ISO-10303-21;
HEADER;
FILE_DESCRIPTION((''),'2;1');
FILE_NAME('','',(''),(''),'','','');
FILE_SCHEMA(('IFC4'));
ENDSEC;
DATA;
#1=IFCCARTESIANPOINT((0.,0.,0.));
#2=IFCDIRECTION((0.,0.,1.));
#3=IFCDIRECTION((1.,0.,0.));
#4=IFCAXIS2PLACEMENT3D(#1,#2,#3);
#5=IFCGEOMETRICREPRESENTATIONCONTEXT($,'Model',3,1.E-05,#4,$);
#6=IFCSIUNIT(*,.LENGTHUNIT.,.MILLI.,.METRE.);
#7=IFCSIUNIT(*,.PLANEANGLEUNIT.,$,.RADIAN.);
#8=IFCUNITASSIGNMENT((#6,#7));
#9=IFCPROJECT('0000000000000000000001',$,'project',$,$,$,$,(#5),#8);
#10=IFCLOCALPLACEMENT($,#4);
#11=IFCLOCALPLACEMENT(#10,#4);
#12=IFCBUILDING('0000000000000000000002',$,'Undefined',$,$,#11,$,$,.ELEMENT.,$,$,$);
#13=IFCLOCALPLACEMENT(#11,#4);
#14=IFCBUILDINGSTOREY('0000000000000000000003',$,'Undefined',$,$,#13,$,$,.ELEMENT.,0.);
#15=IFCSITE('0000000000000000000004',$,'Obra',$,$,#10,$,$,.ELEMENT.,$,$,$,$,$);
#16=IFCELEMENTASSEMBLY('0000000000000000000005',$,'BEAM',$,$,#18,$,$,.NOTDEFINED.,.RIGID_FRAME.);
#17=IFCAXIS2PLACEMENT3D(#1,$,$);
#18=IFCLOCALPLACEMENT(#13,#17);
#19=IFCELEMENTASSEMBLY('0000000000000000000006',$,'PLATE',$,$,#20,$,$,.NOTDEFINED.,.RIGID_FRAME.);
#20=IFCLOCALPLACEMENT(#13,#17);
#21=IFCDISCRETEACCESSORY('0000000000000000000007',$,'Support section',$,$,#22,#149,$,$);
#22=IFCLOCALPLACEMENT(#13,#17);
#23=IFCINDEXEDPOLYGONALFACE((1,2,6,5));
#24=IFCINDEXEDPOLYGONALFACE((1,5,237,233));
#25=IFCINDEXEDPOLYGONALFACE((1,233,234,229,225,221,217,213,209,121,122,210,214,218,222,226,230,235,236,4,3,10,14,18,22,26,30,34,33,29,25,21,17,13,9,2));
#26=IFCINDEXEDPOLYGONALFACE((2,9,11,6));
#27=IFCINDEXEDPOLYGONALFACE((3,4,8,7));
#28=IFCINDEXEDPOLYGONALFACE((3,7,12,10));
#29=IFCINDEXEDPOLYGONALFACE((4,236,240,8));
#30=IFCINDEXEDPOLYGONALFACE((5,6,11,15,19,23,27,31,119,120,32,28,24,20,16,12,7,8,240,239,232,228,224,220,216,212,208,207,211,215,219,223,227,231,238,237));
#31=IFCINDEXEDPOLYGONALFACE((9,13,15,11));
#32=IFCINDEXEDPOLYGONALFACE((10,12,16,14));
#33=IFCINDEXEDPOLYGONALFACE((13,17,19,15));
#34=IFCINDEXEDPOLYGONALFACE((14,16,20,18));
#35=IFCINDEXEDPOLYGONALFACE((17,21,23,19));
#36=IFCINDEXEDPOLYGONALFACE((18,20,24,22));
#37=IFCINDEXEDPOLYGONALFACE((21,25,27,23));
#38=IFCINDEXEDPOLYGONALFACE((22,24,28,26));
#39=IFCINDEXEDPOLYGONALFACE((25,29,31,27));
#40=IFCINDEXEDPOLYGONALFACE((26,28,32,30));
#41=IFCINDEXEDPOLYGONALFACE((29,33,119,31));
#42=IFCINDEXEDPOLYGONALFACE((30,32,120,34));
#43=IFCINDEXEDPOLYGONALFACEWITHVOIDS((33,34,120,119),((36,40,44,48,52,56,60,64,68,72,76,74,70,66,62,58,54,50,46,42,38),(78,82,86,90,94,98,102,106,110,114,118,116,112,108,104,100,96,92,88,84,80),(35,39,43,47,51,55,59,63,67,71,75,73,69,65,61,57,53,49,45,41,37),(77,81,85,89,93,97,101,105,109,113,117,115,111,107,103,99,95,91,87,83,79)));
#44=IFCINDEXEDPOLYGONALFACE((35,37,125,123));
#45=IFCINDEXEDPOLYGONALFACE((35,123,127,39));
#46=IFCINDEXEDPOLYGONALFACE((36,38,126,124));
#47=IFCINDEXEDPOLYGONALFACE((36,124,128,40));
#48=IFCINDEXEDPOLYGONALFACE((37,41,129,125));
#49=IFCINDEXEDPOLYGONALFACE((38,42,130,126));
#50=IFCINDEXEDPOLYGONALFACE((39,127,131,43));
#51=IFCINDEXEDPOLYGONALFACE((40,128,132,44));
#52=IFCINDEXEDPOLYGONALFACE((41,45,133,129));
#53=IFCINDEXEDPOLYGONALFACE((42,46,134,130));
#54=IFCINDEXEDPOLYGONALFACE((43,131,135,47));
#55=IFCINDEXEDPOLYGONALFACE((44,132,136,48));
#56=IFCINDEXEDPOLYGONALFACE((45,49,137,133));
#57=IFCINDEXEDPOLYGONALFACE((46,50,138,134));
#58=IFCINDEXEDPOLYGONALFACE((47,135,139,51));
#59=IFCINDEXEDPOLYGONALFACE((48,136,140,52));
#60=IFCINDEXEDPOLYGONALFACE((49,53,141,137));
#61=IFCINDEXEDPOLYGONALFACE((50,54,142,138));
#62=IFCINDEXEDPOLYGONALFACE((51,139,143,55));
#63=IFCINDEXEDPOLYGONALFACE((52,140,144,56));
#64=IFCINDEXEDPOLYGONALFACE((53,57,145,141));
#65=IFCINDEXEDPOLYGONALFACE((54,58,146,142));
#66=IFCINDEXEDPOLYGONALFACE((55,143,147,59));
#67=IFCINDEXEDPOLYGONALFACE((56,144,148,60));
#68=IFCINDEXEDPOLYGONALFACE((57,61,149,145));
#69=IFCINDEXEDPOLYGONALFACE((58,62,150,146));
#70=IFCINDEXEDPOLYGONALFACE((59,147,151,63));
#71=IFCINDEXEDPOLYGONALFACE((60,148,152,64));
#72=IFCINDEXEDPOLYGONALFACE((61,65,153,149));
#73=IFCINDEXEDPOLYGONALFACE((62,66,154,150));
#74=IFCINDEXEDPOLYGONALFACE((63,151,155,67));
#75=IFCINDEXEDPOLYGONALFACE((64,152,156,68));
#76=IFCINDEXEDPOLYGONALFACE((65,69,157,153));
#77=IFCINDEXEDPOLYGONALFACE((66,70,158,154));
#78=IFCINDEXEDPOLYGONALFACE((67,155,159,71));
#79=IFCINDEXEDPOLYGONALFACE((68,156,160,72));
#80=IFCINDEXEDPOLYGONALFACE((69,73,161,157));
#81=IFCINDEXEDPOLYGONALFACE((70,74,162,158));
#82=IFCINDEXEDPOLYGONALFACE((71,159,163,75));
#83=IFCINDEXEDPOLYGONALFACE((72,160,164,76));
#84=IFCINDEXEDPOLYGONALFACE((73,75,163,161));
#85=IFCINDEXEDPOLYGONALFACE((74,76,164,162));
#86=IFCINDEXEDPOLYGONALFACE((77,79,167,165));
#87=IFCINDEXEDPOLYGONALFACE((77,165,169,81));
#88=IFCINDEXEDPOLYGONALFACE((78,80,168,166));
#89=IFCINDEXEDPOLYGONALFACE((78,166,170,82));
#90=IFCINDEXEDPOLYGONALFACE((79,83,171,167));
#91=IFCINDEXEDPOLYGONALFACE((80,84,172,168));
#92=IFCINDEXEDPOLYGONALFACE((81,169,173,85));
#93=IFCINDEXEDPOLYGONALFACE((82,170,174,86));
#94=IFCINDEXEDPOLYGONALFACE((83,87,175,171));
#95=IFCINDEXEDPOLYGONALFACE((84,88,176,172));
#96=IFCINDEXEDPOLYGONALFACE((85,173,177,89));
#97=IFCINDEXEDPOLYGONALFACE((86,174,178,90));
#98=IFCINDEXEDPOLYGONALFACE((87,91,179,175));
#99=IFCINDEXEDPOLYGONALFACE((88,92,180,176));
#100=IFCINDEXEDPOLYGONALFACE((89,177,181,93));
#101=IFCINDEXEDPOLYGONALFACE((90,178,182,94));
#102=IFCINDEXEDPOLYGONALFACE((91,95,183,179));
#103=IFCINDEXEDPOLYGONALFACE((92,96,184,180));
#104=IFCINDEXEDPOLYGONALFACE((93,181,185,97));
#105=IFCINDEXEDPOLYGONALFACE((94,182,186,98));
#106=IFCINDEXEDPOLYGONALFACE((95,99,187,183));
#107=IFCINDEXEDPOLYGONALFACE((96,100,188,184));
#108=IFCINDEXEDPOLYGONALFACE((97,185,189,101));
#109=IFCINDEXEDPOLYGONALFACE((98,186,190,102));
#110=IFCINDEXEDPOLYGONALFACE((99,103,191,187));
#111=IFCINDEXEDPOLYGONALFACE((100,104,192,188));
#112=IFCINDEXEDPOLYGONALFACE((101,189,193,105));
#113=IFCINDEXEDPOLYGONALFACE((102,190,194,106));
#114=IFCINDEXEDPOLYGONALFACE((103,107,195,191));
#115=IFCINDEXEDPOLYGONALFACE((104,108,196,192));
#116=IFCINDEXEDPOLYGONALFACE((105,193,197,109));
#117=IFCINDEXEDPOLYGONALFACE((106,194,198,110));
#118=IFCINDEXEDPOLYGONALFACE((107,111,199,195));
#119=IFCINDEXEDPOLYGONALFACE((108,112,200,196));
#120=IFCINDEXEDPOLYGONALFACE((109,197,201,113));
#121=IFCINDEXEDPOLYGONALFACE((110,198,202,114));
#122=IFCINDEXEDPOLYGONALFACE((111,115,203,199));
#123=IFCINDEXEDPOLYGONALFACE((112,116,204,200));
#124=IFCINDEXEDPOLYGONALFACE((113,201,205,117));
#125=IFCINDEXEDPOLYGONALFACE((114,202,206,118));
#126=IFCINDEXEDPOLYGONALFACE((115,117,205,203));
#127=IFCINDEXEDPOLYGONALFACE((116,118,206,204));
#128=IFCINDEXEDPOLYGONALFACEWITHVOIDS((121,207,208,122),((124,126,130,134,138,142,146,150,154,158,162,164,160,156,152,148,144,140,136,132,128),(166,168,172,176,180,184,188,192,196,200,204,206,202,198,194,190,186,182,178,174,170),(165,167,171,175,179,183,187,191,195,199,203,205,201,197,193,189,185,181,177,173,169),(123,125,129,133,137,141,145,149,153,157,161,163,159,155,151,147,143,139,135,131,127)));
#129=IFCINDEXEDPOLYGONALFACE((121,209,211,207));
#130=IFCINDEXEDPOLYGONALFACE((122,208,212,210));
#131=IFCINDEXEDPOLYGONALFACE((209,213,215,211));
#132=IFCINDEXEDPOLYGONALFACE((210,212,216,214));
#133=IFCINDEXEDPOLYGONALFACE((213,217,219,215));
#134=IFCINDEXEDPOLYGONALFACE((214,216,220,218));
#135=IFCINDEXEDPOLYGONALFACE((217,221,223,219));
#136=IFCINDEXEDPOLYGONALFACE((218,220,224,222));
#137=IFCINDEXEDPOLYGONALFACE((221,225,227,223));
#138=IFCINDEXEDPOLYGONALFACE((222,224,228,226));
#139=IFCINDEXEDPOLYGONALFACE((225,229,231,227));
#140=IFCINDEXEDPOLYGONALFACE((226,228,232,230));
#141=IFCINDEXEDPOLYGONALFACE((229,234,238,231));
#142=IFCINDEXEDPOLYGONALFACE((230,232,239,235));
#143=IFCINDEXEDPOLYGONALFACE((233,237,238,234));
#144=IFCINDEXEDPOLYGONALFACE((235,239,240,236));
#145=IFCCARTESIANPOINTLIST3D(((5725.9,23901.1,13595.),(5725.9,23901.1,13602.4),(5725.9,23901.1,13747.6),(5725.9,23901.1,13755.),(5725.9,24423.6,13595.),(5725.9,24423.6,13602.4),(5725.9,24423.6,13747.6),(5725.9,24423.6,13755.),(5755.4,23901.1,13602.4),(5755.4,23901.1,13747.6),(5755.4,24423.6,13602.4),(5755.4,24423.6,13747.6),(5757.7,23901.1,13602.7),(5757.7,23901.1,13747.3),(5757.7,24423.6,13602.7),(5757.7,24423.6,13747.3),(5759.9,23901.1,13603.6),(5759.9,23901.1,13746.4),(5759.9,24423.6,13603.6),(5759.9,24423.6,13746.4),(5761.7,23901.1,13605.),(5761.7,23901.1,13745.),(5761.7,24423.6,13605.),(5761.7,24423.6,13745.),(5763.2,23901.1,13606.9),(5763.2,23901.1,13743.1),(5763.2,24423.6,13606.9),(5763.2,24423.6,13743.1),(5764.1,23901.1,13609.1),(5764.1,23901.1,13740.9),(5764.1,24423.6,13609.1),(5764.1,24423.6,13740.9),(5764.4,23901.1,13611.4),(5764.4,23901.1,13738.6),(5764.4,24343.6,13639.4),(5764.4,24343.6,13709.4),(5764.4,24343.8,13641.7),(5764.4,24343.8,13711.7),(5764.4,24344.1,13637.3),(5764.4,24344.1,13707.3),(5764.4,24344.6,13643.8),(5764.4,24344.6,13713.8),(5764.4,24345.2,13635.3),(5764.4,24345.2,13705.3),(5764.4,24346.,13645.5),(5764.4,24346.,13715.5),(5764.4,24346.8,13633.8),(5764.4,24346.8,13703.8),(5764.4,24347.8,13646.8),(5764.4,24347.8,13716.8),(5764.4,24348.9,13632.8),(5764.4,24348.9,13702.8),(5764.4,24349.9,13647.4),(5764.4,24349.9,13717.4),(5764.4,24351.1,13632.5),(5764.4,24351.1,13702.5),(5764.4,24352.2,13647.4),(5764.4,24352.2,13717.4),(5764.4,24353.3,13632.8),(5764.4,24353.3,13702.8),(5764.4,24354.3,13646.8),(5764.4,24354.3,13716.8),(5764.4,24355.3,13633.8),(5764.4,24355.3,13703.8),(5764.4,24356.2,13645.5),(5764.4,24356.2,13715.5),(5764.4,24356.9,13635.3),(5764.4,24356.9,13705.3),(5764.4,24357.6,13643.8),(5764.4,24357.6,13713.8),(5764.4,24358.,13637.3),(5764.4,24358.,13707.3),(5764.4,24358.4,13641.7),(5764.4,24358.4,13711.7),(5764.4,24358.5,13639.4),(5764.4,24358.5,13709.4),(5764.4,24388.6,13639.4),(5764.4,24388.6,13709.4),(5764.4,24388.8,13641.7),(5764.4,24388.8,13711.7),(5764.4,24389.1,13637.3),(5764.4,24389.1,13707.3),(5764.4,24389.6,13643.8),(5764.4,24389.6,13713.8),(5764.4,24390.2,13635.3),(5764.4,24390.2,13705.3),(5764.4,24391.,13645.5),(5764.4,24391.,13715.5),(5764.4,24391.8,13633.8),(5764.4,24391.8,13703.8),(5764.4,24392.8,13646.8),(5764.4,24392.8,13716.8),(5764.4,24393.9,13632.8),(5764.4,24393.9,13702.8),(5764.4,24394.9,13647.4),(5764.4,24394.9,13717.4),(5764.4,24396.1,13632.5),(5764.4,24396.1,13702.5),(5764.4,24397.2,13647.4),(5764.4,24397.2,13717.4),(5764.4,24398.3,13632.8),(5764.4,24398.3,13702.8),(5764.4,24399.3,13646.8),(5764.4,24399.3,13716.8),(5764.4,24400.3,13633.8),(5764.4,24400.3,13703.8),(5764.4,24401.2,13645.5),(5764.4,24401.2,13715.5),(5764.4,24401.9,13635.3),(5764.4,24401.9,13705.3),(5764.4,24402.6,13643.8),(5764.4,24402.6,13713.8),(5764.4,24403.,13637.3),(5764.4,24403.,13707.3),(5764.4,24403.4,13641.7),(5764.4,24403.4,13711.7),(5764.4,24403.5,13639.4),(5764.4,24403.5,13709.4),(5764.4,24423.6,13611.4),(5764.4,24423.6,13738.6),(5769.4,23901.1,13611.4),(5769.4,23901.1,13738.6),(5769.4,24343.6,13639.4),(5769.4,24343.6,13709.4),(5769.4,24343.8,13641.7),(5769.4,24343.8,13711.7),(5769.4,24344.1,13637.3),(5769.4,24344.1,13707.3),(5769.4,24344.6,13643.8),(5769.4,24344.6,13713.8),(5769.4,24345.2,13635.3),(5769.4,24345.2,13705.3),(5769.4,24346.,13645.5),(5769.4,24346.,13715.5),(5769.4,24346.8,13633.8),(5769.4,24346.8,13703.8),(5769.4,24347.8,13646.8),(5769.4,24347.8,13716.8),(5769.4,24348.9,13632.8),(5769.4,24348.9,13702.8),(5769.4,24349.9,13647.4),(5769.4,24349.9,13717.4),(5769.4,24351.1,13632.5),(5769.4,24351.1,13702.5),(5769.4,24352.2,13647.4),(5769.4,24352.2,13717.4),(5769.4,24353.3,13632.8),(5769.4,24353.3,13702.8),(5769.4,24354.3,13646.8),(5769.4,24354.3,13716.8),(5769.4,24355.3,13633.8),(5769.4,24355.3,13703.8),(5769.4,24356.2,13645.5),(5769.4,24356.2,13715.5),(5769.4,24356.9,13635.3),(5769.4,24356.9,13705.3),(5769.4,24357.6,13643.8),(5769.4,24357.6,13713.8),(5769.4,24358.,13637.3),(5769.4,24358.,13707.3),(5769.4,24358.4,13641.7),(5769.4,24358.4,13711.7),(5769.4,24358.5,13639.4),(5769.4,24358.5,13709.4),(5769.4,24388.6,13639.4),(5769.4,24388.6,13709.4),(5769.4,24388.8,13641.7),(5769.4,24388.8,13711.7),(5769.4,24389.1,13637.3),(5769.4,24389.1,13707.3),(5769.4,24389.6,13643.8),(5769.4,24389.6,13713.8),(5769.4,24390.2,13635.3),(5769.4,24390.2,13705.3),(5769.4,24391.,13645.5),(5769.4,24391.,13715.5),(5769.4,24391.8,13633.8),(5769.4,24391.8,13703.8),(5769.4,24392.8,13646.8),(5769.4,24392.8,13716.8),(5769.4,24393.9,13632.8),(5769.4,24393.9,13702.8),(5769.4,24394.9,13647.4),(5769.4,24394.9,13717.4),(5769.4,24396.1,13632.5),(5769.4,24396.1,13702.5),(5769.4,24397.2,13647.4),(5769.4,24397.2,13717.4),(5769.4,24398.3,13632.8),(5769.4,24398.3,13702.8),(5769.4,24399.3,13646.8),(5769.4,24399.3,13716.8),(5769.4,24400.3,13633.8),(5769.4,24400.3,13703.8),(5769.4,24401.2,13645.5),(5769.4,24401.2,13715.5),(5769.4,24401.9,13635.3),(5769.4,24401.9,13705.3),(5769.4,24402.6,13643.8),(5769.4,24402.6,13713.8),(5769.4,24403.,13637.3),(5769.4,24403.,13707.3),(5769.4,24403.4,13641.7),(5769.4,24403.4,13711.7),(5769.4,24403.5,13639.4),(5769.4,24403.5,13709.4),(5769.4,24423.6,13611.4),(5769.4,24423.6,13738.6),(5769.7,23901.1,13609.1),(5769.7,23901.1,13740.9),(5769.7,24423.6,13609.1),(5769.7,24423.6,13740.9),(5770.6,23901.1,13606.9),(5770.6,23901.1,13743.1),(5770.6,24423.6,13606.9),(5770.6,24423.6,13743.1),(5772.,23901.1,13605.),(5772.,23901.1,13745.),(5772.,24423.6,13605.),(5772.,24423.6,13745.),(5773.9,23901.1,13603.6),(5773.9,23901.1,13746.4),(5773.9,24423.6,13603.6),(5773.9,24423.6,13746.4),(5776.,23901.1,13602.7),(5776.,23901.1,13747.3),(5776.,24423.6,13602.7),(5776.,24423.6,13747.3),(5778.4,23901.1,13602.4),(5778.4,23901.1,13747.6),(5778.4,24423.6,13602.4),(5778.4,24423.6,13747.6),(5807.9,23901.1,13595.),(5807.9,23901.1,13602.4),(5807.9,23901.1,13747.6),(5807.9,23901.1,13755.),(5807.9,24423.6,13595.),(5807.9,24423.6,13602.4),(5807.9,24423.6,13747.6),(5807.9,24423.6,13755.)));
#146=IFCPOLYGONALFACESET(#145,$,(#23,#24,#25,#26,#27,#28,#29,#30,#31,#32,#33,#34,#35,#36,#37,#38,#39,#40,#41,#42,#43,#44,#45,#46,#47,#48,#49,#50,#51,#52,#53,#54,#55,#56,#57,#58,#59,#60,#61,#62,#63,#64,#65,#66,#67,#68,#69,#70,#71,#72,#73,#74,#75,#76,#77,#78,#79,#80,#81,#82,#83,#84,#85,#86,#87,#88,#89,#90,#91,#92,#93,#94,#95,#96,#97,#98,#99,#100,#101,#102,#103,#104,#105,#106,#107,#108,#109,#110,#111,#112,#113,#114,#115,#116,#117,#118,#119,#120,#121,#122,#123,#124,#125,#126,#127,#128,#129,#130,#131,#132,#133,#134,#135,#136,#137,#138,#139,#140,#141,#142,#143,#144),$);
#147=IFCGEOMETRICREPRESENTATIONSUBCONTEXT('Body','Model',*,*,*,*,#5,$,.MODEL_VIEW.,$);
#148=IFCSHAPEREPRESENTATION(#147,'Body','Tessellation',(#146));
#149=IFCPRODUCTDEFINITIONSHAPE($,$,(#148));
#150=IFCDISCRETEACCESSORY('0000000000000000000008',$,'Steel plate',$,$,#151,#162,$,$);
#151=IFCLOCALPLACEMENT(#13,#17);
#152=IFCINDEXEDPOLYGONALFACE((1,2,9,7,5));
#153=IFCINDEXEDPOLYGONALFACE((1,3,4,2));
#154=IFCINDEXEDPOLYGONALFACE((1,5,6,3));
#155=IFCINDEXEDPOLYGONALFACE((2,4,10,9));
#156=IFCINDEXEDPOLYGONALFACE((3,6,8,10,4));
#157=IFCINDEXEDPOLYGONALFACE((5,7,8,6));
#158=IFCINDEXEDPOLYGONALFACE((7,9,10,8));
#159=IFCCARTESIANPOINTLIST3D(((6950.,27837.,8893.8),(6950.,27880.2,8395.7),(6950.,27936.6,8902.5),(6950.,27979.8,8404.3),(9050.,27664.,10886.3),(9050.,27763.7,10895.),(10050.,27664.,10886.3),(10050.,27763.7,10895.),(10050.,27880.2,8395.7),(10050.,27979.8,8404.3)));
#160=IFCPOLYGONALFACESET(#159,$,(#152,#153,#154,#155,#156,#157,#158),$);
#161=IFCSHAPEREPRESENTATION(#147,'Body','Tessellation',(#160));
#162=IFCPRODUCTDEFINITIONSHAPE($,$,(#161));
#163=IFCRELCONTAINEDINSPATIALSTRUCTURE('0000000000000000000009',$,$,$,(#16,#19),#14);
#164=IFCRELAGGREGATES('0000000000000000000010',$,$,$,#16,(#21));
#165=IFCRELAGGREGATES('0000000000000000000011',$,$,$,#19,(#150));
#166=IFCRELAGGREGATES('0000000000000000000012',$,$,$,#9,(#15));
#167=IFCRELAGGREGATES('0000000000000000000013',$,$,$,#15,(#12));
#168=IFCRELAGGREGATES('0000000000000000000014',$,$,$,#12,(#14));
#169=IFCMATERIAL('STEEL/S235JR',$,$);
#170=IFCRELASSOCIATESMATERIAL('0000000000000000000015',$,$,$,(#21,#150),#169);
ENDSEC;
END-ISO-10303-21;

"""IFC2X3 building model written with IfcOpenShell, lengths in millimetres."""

from ifc_helpers import new_model, si_unit, frame, origin_with_axes, origin_2d_with_axis, place, context, subcontext, project, spatial, polyline, circle, i_section, outline, extrude, clip, halfspace, source, transform, mapped, material, element, aggregate, save


model = new_model("IFC2X3")

# Units and contexts
model_context = context("Model", 3, precision=1e-05, world=origin_with_axes())
body_context = subcontext(model_context, "Body", "Model", "MODEL_VIEW")
ifc_project = project(units=[si_unit("LENGTHUNIT", "METRE", prefix="MILLI"), si_unit("PLANEANGLEUNIT", "RADIAN")], contexts=[model_context])

# Site, building, storey
site_placement = place(None, origin_with_axes())
site = spatial("IfcSite", under=ifc_project, at=site_placement, Name="Obra", CompositionType="ELEMENT")
building_placement = place(site_placement, origin_with_axes())
building = spatial("IfcBuilding", under=site, at=building_placement, Name="Undefined", CompositionType="ELEMENT")
storey_placement = place(building_placement, origin_with_axes())
storey = spatial("IfcBuildingStorey", under=building, at=storey_placement, Name="Undefined", CompositionType="ELEMENT", Elevation=0.0)

# Element assembly
assembly_1_placement = place(storey_placement, origin_with_axes())
assembly_1 = element("IfcElementAssembly", 1, at=assembly_1_placement, inside=storey, Name="BEAM", AssemblyPlace="NOTDEFINED", PredefinedType="RIGID_FRAME")
ifc_material_1 = material(Name="STEEL/S235JR")

# Shared definitions
shared_shape_1 = source(origin_with_axes(), body_context, "Body", "SweptSolid", [
    extrude(circle(Radius=7.5, at=origin_2d_with_axis()), frame((0.0, -2.6, 0.0), z_axis=(0.0, 1.0, 0.0), x_axis=(1.0, 0.0, 0.0)), (0.0, 0.0, 1.0), 5.2),
])

# Element assembly
assembly_2_placement = place(storey_placement, origin_with_axes())
assembly_2 = element("IfcElementAssembly", 2, at=assembly_2_placement, inside=storey, Name="PLATE", AssemblyPlace="NOTDEFINED", PredefinedType="RIGID_FRAME")

# Discrete accessory, opening
discrete_accessory_1_placement = place(assembly_1_placement, frame((5766.9, 23991.9, 13675.0), z_axis=(0.0, 0.0, 1.0), x_axis=(0.0, 1.0, 0.0)))
discrete_accessory_1 = element("IfcDiscreteAccessory", 3, at=discrete_accessory_1_placement, material=ifc_material_1, Name="Support section", context=body_context, shape_type="Clipping", body=[
    clip(clip(extrude(i_section(OverallWidth=82.0, OverallDepth=160.0, WebThickness=5.0, FlangeThickness=7.4, FilletRadius=9.0, at=origin_2d_with_axis()), frame((431.7, 0.0, 0.0), z_axis=(-1.0, 0.0, 0.0), x_axis=(0.0, -1.0, 0.0)), (0.0, 0.0, 1.0), 522.5), halfspace(frame((431.7, 0.0, -180.0), z_axis=(-1.0, 0.0, 0.0), x_axis=(0.0, 1.0, 0.0)), True)), halfspace(frame((-90.7, 0.0, 580.0), z_axis=(-1.0, -0.000446, 0.0), x_axis=(0.000446, -1.0, 0.0)), False)),
])
opening_1_placement = place(assembly_1_placement, frame((5766.9, 24373.6, 13710.0), z_axis=(0.0, -1.0, 0.0), x_axis=(0.0, 0.0, -1.0)))
element("IfcOpeningElement", 4, at=opening_1_placement, cuts=discrete_accessory_1, ObjectType="Opening", context=body_context, shape_type="MappedRepresentation", body=[
    mapped(shared_shape_1, transform((0.0, 0.0, -22.5))),
    mapped(shared_shape_1, transform((70.0, 0.0, -22.5))),
    mapped(shared_shape_1, transform((0.0, 0.0, 22.5))),
    mapped(shared_shape_1, transform((70.0, 0.0, 22.5))),
])
aggregate(assembly_1, [discrete_accessory_1])

# Discrete accessory
discrete_accessory_2_placement = place(assembly_2_placement, frame((6950.0, 27886.8, 8898.1), z_axis=(0.0, -0.996255, -0.08646), x_axis=(0.0, 0.08646, -0.996255)))
discrete_accessory_2 = element("IfcDiscreteAccessory", 5, at=discrete_accessory_2_placement, material=ifc_material_1, Name="Steel plate", context=body_context, shape_type="SweptSolid", body=[
    extrude(outline(polyline([(0.0, 0.0), (500.0, 0.0), (500.0, 3100.0), (-2000.0, 3100.0), (-2000.0, 2100.0), (0.0, 0.0)])), frame((0.0, 0.0, -50.0), z_axis=(0.0, 0.0, 1.0), x_axis=(1.0, 0.0, 0.0)), (0.0, 0.0, 1.0), 100.0),
])
aggregate(assembly_2, [discrete_accessory_2])

save(model, "model.ifc")
